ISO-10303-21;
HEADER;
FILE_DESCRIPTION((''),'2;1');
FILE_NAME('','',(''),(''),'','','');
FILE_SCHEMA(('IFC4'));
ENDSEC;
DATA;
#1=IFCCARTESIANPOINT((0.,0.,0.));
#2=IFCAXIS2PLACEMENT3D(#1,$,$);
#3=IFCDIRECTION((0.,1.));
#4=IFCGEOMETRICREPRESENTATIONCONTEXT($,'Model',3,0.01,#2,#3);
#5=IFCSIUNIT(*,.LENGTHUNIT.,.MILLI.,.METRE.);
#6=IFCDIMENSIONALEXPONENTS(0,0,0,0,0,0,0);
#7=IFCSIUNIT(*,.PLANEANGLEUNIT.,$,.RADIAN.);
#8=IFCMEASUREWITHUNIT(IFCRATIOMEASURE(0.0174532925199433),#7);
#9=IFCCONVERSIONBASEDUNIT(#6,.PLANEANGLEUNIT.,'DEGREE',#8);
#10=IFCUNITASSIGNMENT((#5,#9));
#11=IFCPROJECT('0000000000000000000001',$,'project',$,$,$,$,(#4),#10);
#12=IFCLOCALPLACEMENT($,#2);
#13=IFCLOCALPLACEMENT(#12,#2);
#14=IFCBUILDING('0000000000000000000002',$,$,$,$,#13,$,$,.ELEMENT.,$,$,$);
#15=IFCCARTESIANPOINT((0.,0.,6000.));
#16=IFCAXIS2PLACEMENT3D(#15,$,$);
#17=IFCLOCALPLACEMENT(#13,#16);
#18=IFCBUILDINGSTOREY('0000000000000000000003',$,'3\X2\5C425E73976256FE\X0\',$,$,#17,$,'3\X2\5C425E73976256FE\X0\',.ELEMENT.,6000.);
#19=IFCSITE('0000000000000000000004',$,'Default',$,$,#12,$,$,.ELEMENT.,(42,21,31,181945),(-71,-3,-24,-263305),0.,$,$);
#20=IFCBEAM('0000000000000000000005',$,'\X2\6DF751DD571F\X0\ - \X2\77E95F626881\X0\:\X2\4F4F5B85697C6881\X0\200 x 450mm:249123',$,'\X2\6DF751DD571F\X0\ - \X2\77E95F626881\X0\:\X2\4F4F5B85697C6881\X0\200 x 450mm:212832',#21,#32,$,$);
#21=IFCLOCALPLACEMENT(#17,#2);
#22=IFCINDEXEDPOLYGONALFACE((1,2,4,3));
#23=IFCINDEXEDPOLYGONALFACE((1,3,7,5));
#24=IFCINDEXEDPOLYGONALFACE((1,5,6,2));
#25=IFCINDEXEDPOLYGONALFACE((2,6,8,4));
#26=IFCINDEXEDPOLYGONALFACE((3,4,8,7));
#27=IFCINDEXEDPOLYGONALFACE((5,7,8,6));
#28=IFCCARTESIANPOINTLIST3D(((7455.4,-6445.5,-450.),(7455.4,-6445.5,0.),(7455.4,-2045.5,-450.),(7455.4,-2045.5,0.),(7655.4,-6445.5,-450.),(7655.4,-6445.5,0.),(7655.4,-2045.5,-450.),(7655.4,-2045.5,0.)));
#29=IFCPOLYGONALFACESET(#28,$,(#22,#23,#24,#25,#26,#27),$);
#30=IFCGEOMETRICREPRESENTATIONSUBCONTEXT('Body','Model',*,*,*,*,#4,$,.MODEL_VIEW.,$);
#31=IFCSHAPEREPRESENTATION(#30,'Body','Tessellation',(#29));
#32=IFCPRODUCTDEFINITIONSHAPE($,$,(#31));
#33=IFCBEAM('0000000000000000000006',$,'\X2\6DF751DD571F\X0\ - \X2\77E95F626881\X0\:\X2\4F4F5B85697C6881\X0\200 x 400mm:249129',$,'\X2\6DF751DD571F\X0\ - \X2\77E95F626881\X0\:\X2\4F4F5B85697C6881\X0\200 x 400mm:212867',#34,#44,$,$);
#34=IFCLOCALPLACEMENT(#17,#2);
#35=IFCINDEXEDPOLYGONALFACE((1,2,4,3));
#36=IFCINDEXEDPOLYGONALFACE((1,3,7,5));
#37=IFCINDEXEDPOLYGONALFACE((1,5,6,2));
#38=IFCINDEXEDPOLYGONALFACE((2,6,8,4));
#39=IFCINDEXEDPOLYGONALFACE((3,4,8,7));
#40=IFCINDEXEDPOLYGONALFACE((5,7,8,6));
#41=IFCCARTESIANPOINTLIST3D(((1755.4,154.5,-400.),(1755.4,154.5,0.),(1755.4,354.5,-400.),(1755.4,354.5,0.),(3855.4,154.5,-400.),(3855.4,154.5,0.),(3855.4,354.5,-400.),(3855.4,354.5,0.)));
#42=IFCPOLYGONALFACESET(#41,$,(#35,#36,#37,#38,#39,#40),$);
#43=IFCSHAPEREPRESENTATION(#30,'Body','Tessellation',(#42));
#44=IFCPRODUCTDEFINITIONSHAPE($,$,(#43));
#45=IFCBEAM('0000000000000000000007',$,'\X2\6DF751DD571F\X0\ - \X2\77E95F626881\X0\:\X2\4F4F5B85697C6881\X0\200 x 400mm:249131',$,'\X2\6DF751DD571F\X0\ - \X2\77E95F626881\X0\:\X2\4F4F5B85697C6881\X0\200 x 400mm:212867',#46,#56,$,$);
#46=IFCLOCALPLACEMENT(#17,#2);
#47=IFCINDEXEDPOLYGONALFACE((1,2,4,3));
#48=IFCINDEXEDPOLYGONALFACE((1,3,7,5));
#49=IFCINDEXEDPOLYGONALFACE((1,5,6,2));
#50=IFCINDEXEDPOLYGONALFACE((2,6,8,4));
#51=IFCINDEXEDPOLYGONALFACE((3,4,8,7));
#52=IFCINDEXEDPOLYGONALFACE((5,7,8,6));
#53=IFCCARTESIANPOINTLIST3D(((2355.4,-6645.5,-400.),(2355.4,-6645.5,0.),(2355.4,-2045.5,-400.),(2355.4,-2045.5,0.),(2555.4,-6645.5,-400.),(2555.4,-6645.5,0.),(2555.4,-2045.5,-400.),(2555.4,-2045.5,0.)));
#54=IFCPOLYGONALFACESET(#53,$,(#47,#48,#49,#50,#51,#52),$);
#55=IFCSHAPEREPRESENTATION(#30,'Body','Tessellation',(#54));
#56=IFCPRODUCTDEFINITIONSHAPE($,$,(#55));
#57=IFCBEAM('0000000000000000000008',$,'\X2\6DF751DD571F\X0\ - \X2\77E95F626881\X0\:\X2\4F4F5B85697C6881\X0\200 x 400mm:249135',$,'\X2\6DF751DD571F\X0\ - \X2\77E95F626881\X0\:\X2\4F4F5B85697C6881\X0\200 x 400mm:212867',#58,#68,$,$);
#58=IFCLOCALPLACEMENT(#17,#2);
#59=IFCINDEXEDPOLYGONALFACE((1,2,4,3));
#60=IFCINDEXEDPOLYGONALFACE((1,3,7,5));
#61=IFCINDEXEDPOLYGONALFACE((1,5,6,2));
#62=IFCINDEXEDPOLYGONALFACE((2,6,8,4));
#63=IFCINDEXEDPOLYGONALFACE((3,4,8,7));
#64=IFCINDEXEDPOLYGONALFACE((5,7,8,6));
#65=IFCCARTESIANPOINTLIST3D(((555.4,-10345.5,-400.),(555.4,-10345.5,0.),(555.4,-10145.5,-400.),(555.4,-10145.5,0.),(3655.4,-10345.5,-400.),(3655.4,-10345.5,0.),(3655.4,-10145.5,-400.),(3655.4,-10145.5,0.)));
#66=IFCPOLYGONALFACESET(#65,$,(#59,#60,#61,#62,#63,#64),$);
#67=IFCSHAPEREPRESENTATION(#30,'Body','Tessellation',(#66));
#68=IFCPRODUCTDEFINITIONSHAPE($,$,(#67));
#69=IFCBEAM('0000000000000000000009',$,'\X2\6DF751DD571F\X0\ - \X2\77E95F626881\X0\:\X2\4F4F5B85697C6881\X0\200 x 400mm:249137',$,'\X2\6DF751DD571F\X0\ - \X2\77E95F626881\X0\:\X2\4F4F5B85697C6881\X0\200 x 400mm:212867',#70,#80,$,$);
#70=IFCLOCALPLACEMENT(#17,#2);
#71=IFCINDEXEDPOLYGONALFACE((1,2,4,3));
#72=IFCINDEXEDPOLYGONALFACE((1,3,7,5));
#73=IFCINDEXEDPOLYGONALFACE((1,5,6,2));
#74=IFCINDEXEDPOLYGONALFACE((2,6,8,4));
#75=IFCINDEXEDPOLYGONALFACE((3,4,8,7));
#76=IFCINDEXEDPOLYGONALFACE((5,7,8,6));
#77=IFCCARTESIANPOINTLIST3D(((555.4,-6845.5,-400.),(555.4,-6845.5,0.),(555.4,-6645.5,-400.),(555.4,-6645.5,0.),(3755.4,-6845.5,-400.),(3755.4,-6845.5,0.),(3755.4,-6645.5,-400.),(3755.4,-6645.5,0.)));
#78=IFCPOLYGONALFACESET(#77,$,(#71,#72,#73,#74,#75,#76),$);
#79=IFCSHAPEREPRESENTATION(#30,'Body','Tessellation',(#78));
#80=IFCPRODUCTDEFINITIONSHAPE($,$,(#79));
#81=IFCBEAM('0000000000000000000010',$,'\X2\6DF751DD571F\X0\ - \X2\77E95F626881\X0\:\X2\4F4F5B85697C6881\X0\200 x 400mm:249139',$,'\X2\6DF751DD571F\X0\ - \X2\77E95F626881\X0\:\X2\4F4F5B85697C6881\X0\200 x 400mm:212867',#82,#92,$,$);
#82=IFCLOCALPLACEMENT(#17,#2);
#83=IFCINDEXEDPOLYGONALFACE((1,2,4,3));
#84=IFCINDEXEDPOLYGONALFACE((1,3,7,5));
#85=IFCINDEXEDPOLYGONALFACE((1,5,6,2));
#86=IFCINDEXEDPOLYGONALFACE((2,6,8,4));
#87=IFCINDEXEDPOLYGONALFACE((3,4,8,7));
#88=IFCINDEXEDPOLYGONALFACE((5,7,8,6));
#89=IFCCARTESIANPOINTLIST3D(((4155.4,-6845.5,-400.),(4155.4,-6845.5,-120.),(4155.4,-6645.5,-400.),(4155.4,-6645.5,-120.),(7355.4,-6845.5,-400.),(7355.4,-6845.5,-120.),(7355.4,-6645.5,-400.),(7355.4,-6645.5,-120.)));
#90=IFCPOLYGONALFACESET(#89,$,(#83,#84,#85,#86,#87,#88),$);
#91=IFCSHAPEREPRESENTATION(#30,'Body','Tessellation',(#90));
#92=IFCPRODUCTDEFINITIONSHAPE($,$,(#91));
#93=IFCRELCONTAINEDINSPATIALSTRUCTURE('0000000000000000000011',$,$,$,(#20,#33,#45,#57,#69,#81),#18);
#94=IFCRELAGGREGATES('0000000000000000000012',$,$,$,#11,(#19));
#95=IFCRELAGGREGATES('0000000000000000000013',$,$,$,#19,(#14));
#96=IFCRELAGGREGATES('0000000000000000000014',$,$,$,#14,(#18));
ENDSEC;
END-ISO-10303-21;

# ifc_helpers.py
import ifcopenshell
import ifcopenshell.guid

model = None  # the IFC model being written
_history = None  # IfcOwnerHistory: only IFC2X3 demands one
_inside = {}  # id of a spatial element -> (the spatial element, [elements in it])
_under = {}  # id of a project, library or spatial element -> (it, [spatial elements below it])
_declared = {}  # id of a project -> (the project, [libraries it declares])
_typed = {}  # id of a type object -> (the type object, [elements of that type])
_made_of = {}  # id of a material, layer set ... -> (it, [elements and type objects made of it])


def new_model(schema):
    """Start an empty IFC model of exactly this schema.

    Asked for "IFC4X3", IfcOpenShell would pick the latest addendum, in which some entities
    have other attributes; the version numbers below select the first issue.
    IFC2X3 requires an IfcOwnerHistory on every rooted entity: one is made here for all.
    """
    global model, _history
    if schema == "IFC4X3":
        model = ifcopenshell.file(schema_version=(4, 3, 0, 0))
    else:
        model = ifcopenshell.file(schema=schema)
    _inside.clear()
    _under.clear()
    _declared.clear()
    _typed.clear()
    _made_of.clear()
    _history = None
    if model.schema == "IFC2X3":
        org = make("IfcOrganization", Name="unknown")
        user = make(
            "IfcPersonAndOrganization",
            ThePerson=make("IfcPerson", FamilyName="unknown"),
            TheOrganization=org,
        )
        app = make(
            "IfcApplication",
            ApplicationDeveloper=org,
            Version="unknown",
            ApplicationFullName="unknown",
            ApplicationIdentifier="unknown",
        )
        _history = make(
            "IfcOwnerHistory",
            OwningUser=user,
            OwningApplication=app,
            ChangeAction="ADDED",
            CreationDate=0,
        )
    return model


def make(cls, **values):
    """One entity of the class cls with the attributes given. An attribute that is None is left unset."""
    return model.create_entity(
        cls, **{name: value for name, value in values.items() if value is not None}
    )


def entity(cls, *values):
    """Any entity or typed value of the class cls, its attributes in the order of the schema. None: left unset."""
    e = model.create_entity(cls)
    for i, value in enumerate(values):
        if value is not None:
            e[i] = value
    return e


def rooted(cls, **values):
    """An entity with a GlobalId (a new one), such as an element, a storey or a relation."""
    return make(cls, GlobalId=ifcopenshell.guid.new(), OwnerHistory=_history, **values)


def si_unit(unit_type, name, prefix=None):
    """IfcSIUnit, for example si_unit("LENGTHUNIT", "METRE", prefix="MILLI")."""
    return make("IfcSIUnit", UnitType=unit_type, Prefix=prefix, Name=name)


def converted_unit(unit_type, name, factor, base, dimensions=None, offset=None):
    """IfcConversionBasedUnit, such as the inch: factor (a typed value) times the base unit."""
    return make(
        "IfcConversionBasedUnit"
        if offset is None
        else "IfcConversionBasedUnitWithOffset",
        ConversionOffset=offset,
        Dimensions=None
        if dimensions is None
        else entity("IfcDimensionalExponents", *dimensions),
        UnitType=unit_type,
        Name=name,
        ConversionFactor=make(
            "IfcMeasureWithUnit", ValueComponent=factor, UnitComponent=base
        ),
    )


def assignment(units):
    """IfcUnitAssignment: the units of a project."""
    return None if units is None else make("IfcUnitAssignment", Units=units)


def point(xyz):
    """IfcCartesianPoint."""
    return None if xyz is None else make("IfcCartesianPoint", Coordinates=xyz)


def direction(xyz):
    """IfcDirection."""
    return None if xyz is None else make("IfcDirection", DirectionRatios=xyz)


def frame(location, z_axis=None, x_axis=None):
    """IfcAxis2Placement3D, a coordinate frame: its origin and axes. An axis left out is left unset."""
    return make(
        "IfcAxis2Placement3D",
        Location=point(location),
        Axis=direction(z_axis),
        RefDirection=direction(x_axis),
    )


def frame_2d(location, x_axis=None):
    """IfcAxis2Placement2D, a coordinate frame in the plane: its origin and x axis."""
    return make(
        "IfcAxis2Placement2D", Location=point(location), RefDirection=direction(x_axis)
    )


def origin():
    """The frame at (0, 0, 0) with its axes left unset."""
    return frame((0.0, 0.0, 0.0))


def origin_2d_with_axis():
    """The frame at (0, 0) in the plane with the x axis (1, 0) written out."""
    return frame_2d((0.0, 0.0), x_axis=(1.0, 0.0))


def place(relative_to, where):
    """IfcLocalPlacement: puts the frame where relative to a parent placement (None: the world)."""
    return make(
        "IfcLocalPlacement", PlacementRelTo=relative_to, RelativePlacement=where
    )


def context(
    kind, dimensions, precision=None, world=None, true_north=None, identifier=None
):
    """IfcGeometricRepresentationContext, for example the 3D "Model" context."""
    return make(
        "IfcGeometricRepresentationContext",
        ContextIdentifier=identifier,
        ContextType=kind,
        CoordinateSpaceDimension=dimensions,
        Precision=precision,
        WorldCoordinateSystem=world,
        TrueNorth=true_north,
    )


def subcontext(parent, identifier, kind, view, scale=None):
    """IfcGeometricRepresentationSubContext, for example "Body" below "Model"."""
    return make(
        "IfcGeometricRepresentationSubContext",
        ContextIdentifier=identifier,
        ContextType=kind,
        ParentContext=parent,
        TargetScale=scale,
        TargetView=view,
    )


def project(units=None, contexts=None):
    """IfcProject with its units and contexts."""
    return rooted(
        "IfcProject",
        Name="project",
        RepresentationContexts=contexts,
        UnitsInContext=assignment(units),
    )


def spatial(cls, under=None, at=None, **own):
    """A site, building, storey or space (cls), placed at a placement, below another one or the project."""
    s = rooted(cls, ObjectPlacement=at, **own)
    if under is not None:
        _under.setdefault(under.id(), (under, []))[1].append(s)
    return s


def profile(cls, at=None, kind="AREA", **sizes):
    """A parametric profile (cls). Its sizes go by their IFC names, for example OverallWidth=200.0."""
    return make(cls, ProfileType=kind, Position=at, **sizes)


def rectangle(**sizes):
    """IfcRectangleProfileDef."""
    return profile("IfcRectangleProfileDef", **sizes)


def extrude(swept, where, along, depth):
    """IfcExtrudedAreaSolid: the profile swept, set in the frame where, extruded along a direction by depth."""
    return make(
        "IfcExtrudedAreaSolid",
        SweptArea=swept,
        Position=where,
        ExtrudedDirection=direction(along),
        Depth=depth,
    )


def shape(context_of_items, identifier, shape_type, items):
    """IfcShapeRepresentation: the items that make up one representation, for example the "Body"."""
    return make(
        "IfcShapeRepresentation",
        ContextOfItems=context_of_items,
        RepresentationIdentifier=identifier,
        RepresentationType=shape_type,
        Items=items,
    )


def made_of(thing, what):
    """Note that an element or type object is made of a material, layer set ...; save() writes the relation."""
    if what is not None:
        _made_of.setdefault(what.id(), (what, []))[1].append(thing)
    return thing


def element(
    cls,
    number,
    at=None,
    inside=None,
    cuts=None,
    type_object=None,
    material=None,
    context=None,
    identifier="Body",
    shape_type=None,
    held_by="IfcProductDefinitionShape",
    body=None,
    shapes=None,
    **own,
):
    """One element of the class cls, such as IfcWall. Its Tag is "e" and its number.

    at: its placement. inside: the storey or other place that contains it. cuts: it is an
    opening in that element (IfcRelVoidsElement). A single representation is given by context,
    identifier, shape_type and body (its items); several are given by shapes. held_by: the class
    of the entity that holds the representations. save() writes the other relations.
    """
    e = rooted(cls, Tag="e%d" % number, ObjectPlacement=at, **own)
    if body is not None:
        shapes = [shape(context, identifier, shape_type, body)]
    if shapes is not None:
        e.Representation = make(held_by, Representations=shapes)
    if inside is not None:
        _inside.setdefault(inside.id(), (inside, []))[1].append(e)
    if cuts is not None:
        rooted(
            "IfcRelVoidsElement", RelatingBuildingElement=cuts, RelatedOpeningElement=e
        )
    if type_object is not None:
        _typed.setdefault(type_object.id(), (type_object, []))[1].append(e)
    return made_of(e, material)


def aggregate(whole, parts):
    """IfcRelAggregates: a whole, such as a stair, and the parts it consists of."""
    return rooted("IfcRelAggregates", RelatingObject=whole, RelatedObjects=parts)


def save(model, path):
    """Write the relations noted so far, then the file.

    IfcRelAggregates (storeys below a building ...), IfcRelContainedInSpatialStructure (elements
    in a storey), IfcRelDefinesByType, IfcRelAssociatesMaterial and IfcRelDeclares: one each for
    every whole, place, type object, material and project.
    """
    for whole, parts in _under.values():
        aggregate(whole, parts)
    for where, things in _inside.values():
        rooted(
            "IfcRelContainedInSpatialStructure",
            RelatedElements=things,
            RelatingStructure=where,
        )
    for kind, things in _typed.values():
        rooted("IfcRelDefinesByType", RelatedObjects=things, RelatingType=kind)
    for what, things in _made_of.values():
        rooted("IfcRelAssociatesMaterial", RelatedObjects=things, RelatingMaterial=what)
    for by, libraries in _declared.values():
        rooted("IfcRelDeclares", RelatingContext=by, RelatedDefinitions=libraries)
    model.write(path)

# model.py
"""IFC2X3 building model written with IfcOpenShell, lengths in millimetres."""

from ifc_helpers import new_model, entity, si_unit, converted_unit, direction, frame, frame_2d, origin, origin_2d_with_axis, place, context, subcontext, project, spatial, rectangle, extrude, element, save


model = new_model("IFC2X3")

# Units and contexts
model_context = context("Model", 3, precision=0.01, world=origin(), true_north=direction((0.0, 1.0)))
body_context = subcontext(model_context, "Body", "Model", "MODEL_VIEW")
ifc_project = project(units=[si_unit("LENGTHUNIT", "METRE", prefix="MILLI"), converted_unit("PLANEANGLEUNIT", "DEGREE", entity("IfcRatioMeasure", 0.0174532925199433), si_unit("PLANEANGLEUNIT", "RADIAN"), dimensions=[0, 0, 0, 0, 0, 0, 0])], contexts=[model_context])

# Site, building, storey
site_placement = place(None, origin())
site = spatial("IfcSite", under=ifc_project, at=site_placement, Name="Default", CompositionType="ELEMENT", RefLatitude=(42, 21, 31, 181945), RefLongitude=(-71, -3, -24, -263305), RefElevation=0.0)
building_placement = place(site_placement, origin())
building = spatial("IfcBuilding", under=site, at=building_placement, CompositionType="ELEMENT")
storey_placement = place(building_placement, frame((0.0, 0.0, 6000.0)))
storey = spatial("IfcBuildingStorey", under=building, at=storey_placement, Name="3层平面图", LongName="3层平面图", CompositionType="ELEMENT", Elevation=6000.0)

# Beams
beam_1_placement = place(storey_placement, frame((7555.4, -1945.5, 0.0), z_axis=(0.0, 0.0, 1.0), x_axis=(0.0, -1.0, 0.0)))
element("IfcBeam", 1, at=beam_1_placement, inside=storey, Name="混凝土 - 矩形梁:住宅楼梁200 x 450mm:249123", ObjectType="混凝土 - 矩形梁:住宅楼梁200 x 450mm:212832", context=body_context, shape_type="SweptSolid", body=[
    extrude(rectangle(XDim=450.0, YDim=200.0, at=frame_2d((0.0, 0.0), x_axis=(1.0, 0.0))), frame((100.0, 0.0, -225.0), z_axis=(1.0, 0.0, 0.0), x_axis=(0.0, 0.0, -1.0)), (0.0, 0.0, 1.0), 4400.0),
])
beam_2_placement = place(storey_placement, frame((3955.4, 254.5, 0.0), z_axis=(0.0, 0.0, 1.0), x_axis=(-1.0, 0.0, 0.0)))
element("IfcBeam", 2, at=beam_2_placement, inside=storey, Name="混凝土 - 矩形梁:住宅楼梁200 x 400mm:249129", ObjectType="混凝土 - 矩形梁:住宅楼梁200 x 400mm:212867", context=body_context, shape_type="SweptSolid", body=[
    extrude(rectangle(XDim=400.0, YDim=200.0, at=frame_2d((0.0, 0.0), x_axis=(1.0, 0.0))), frame((100.0, 0.0, -200.0), z_axis=(1.0, 0.0, 0.0), x_axis=(0.0, 0.0, -1.0)), (0.0, 0.0, 1.0), 2100.0),
])
beam_3_placement = place(storey_placement, frame((2455.4, -1945.5, 0.0), z_axis=(0.0, 0.0, 1.0), x_axis=(0.0, -1.0, 0.0)))
element("IfcBeam", 3, at=beam_3_placement, inside=storey, Name="混凝土 - 矩形梁:住宅楼梁200 x 400mm:249131", ObjectType="混凝土 - 矩形梁:住宅楼梁200 x 400mm:212867", context=body_context, shape_type="SweptSolid", body=[
    extrude(rectangle(XDim=400.0, YDim=200.0, at=origin_2d_with_axis()), frame((100.0, 0.0, -200.0), z_axis=(1.0, 0.0, 0.0), x_axis=(0.0, 0.0, -1.0)), (0.0, 0.0, 1.0), 4600.0),
])
beam_4_placement = place(storey_placement, frame((3655.4, -10245.5, 0.0), z_axis=(0.0, 0.0, 1.0), x_axis=(-1.0, 0.0, 0.0)))
element("IfcBeam", 4, at=beam_4_placement, inside=storey, Name="混凝土 - 矩形梁:住宅楼梁200 x 400mm:249135", ObjectType="混凝土 - 矩形梁:住宅楼梁200 x 400mm:212867", context=body_context, shape_type="SweptSolid", body=[
    extrude(rectangle(XDim=400.0, YDim=200.0, at=frame_2d((0.0, 0.0), x_axis=(1.0, 0.0))), frame((0.0, 0.0, -200.0), z_axis=(1.0, 0.0, 0.0), x_axis=(0.0, 0.0, -1.0)), (0.0, 0.0, 1.0), 3100.0),
])
beam_5_placement = place(storey_placement, frame((3955.4, -6745.5, 0.0), z_axis=(0.0, 0.0, 1.0), x_axis=(-1.0, 0.0, 0.0)))
element("IfcBeam", 5, at=beam_5_placement, inside=storey, Name="混凝土 - 矩形梁:住宅楼梁200 x 400mm:249137", ObjectType="混凝土 - 矩形梁:住宅楼梁200 x 400mm:212867", context=body_context, shape_type="SweptSolid", body=[
    extrude(rectangle(XDim=400.0, YDim=200.0, at=frame_2d((0.0, 0.0), x_axis=(1.0, 0.0))), frame((200.0, 0.0, -200.0), z_axis=(1.0, 0.0, 0.0), x_axis=(0.0, 0.0, -1.0)), (0.0, 0.0, 1.0), 3200.0),
])
beam_6_placement = place(storey_placement, frame((3955.4, -6745.5, 0.0)))
element("IfcBeam", 6, at=beam_6_placement, inside=storey, Name="混凝土 - 矩形梁:住宅楼梁200 x 400mm:249139", ObjectType="混凝土 - 矩形梁:住宅楼梁200 x 400mm:212867", context=body_context, shape_type="SweptSolid", body=[
    extrude(rectangle(XDim=280.0, YDim=200.0, at=frame_2d((0.0, 0.0), x_axis=(1.0, 0.0))), frame((200.0, 0.0, -260.0), z_axis=(1.0, 0.0, 0.0), x_axis=(0.0, 0.0, -1.0)), (0.0, 0.0, 1.0), 3200.0),
])

save(model, "model.ifc")
